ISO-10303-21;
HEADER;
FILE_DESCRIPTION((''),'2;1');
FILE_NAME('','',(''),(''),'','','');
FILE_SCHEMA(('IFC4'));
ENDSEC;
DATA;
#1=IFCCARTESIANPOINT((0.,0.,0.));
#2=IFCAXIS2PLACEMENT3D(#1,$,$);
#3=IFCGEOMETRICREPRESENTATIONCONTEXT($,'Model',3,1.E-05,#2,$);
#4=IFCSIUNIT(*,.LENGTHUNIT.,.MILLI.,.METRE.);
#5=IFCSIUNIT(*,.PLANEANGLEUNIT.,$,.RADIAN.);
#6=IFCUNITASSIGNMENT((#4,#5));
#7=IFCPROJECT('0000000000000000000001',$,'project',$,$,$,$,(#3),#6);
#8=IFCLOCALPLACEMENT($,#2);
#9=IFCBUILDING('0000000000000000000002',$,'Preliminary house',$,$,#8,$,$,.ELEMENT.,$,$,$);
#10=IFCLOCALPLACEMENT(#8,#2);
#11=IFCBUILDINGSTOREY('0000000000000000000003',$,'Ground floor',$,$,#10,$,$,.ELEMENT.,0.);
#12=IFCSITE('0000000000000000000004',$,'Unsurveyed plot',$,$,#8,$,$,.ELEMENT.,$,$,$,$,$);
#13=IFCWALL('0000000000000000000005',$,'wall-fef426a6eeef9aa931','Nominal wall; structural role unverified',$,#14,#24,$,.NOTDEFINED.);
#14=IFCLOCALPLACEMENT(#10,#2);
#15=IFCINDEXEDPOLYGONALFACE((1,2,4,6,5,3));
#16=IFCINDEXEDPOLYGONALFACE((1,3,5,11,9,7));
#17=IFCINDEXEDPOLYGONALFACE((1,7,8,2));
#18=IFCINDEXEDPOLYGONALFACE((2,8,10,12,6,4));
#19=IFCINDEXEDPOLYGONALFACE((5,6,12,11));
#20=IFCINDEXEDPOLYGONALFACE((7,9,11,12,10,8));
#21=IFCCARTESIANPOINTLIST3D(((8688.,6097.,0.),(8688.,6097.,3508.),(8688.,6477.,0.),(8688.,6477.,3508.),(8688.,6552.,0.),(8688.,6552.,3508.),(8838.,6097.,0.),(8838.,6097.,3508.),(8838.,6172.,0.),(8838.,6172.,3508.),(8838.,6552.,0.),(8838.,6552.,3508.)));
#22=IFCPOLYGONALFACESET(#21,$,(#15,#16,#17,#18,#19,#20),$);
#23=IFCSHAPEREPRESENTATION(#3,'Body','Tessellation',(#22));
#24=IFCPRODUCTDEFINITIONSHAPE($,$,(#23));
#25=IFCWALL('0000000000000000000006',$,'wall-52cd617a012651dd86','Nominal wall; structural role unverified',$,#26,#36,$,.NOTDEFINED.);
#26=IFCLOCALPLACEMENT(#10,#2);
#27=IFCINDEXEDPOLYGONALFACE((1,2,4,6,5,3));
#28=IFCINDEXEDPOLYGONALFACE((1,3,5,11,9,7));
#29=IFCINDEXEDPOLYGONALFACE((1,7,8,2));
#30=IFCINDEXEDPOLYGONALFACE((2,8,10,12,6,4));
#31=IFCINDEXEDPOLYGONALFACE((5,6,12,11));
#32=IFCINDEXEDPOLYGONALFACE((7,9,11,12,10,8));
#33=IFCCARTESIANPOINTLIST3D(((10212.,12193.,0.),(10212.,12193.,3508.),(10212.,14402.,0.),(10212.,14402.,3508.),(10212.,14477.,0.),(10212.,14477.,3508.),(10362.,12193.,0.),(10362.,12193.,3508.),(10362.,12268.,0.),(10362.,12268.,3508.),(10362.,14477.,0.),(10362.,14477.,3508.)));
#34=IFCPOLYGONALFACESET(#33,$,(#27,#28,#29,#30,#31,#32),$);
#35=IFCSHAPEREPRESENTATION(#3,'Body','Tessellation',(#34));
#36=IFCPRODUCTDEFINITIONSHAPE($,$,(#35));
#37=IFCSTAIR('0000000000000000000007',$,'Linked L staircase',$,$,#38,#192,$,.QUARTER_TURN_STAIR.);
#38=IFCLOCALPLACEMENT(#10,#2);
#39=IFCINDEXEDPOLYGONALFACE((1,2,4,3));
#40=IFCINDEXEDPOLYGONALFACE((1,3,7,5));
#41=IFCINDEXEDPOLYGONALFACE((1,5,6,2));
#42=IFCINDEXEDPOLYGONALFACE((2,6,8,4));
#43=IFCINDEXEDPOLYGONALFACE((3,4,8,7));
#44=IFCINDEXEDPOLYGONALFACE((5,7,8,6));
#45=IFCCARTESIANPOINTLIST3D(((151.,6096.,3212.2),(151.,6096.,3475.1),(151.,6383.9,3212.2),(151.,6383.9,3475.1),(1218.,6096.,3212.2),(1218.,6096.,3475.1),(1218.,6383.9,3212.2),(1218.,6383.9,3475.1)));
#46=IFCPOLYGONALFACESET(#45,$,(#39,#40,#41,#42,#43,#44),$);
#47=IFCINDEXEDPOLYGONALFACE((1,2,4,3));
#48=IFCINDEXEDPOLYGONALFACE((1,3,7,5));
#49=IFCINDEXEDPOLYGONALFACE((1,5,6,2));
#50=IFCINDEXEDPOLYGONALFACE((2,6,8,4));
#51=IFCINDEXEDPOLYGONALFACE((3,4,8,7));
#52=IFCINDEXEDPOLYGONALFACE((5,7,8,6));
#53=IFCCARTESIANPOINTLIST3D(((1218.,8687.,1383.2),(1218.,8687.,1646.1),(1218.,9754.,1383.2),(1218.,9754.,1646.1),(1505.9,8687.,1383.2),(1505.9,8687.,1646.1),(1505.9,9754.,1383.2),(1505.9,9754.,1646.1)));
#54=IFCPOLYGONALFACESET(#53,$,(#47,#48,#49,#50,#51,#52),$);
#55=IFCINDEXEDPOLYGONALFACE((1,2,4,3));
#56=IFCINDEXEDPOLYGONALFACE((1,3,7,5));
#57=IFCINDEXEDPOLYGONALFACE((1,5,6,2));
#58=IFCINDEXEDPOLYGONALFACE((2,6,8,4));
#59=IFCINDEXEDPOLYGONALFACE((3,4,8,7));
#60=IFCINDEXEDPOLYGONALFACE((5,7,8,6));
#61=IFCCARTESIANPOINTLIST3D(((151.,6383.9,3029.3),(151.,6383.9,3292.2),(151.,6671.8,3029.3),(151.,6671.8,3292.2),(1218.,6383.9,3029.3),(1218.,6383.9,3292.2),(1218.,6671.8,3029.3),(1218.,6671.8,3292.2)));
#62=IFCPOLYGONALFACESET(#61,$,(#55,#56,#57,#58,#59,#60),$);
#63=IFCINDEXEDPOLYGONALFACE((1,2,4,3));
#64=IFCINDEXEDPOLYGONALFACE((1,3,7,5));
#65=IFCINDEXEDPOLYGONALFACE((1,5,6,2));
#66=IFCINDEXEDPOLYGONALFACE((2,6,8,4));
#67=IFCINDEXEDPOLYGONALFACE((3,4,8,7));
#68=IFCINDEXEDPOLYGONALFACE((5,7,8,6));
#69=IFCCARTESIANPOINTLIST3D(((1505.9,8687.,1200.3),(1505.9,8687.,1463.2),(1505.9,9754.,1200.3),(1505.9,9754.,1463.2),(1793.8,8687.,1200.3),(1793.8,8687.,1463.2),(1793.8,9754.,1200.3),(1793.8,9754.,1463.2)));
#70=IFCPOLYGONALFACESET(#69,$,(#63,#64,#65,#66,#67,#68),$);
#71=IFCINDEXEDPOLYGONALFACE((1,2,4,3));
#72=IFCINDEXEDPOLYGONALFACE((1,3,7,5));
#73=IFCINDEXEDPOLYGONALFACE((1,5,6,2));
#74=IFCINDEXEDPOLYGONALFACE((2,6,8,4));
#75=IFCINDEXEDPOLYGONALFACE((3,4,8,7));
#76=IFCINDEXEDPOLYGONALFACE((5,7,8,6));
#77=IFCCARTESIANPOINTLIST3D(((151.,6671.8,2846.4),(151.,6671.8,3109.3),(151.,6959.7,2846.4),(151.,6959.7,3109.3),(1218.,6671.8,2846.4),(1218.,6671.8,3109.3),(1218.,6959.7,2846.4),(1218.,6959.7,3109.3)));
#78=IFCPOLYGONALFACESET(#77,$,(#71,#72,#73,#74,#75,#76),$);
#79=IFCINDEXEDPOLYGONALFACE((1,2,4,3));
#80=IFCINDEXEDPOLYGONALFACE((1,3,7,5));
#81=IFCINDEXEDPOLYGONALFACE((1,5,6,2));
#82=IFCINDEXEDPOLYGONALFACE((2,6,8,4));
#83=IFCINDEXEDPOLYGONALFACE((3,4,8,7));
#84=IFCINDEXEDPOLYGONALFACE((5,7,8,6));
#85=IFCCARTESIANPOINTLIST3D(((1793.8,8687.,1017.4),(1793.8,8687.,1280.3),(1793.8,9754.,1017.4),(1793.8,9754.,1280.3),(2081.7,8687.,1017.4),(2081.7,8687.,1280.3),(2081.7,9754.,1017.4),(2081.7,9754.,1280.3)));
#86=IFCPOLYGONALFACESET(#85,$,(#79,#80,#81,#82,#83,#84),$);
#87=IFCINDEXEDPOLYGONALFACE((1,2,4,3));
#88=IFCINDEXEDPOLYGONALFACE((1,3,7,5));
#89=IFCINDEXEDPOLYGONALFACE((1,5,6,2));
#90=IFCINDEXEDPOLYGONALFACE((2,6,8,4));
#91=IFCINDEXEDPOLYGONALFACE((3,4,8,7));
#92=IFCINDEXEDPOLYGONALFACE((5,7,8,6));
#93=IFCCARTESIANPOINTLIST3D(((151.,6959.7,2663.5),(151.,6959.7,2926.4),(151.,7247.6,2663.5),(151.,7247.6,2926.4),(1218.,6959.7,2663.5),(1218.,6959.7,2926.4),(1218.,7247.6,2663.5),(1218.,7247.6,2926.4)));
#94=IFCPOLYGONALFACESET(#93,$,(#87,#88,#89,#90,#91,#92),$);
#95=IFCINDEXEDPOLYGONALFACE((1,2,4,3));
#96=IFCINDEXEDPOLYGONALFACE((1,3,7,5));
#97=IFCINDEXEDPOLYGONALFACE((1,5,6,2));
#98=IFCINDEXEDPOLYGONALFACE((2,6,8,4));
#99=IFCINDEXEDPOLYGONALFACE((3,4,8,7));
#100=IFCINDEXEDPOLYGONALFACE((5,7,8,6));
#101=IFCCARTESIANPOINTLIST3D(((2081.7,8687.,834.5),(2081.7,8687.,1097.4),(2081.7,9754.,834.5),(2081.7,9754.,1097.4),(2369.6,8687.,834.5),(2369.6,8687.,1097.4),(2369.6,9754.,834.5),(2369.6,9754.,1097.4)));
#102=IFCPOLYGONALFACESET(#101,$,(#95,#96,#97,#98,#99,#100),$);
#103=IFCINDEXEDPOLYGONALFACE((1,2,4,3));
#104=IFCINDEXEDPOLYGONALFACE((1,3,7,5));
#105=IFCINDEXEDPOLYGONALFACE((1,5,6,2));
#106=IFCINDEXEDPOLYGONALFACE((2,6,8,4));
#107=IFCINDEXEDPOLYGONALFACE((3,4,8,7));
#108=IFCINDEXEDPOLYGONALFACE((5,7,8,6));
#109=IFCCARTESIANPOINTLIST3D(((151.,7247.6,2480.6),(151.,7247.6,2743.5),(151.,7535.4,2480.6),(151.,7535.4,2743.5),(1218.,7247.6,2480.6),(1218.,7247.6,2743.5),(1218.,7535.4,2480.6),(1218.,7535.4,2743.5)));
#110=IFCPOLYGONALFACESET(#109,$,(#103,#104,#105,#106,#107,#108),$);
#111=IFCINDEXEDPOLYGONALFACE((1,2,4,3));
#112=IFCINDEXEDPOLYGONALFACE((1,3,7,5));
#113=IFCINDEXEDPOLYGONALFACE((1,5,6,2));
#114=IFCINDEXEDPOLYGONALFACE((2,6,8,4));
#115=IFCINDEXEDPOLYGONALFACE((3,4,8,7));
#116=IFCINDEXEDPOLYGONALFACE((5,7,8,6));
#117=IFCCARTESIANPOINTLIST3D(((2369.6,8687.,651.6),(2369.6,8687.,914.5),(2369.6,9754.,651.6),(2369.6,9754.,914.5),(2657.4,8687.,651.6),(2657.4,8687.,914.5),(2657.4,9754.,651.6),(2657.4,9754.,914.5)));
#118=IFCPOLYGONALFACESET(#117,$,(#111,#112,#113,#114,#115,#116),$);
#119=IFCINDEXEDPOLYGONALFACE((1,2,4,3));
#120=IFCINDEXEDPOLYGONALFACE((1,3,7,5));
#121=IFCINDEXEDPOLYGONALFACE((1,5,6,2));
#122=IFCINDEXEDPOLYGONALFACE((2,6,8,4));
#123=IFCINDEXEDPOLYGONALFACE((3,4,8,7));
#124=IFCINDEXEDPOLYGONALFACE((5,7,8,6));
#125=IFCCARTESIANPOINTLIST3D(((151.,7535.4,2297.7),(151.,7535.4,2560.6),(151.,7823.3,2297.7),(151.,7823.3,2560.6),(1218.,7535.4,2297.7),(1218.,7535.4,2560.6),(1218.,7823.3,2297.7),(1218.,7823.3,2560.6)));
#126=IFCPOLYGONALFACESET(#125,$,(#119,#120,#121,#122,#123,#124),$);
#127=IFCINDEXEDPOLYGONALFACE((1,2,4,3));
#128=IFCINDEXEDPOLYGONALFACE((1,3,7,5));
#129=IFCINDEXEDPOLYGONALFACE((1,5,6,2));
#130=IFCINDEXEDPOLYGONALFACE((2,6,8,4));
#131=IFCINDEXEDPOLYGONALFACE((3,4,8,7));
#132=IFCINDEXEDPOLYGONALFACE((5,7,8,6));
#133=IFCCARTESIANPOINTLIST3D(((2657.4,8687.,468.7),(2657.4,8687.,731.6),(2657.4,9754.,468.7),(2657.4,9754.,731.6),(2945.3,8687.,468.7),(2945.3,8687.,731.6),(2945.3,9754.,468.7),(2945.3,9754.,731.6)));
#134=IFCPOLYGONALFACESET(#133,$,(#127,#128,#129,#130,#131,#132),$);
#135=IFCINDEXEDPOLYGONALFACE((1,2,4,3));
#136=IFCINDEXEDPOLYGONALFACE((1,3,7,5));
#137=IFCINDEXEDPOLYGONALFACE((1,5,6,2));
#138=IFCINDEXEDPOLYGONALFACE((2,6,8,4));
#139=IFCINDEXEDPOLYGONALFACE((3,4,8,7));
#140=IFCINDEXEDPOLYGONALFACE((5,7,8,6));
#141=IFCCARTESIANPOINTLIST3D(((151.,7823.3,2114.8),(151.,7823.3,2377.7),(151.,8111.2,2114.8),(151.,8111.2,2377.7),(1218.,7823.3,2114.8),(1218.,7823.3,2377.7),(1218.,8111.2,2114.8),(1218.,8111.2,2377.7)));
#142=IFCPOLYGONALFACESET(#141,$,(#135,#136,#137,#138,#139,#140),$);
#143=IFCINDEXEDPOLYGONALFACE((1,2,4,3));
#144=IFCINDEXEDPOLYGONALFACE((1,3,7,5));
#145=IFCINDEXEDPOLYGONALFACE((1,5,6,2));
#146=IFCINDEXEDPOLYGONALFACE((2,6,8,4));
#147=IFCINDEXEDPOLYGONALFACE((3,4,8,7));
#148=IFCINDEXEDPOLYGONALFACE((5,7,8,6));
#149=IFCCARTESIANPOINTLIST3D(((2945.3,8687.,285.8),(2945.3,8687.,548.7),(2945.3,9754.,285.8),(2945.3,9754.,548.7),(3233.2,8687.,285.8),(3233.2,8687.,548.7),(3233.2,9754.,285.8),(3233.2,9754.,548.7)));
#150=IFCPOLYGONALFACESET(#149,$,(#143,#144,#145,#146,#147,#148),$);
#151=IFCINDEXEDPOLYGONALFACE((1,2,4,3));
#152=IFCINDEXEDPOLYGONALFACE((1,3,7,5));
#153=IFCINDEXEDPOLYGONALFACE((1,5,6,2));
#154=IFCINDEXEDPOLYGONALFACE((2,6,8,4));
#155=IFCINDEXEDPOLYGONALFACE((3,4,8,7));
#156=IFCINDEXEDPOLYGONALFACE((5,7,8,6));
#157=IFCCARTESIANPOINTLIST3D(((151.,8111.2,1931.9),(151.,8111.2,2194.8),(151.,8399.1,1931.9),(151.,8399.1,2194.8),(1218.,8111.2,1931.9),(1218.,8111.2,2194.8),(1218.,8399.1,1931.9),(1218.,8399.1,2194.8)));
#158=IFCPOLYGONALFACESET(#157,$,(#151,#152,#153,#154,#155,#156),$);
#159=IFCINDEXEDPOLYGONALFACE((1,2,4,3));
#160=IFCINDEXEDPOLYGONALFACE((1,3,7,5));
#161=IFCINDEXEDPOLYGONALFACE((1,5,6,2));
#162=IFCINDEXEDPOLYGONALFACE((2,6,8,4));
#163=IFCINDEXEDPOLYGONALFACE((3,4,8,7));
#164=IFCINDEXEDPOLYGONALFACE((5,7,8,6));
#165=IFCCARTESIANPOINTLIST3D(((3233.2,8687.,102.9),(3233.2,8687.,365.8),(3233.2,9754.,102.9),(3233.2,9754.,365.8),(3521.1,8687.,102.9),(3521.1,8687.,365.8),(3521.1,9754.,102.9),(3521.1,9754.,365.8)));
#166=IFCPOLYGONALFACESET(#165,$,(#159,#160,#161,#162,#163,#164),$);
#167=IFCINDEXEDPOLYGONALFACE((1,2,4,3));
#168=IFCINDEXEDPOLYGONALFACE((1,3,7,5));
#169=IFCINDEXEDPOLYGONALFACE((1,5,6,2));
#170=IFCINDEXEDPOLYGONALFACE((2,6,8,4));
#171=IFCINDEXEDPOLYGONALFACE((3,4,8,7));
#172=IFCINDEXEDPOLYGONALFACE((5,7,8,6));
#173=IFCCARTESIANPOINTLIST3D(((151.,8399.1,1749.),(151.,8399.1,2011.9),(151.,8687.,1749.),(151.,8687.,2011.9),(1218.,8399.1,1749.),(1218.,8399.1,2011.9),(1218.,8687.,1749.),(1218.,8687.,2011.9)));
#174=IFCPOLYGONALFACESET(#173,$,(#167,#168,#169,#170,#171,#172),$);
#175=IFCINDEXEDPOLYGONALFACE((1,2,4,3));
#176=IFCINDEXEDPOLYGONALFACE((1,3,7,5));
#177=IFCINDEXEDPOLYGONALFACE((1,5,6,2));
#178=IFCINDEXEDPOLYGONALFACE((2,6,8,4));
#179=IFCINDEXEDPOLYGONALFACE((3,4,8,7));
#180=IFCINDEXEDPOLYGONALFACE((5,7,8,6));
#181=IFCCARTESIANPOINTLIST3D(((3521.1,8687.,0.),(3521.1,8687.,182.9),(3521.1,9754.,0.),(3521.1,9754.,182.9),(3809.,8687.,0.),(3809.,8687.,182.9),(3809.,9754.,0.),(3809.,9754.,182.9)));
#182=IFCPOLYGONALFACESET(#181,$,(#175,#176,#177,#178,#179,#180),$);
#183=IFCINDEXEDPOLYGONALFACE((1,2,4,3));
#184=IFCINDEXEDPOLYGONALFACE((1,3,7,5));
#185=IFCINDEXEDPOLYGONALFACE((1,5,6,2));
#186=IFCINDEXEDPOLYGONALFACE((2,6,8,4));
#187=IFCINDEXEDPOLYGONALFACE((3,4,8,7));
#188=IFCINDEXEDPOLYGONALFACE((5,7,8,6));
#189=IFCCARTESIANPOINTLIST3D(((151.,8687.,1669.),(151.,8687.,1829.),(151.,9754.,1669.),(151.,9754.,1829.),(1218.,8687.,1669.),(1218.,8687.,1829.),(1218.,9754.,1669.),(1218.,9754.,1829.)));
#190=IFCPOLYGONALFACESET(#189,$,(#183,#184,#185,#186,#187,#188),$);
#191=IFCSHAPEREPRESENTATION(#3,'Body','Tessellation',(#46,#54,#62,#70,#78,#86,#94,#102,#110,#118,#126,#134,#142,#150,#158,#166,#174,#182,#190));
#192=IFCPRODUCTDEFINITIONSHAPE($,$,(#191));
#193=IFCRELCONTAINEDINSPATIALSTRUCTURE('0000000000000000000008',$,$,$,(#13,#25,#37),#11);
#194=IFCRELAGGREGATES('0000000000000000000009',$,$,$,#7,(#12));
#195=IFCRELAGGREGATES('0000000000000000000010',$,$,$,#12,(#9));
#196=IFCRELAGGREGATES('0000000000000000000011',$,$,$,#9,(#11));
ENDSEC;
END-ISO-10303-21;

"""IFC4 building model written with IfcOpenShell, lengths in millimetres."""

from ifc_helpers import new_model, si_unit, frame, origin, place, context, project, spatial, polyline, outline, extrude, element, save


model = new_model("IFC4")

# Units and contexts
model_context = context("Model", 3, precision=1e-05, world=origin())
ifc_project = project(units=[si_unit("LENGTHUNIT", "METRE", prefix="MILLI"), si_unit("PLANEANGLEUNIT", "RADIAN")], contexts=[model_context])

# Site, building, storey
placement_1 = place(None, origin())
site = spatial("IfcSite", under=ifc_project, at=placement_1, Name="Unsurveyed plot", CompositionType="ELEMENT")
building = spatial("IfcBuilding", under=site, at=placement_1, Name="Preliminary house", CompositionType="ELEMENT")
placement_2 = place(placement_1, origin())
storey = spatial("IfcBuildingStorey", under=building, at=placement_2, Name="Ground floor", CompositionType="ELEMENT", Elevation=0.0)

# Wall
element("IfcWall", 1, at=placement_2, inside=storey, Name="wall-fef426a6eeef9aa931", Description="Nominal wall; structural role unverified", PredefinedType="NOTDEFINED", context=model_context, shape_type="SweptSolid", body=[
    extrude(outline(polyline([(8688.0, 6477.0), (8688.0, 6552.0), (8838.0, 6552.0), (8838.0, 6172.0), (8838.0, 6097.0), (8688.0, 6097.0), (8688.0, 6477.0)])), origin(), (0.0, 0.0, 1.0), 3508.0),
])

# Wall
element("IfcWall", 2, at=placement_2, inside=storey, Name="wall-52cd617a012651dd86", Description="Nominal wall; structural role unverified", PredefinedType="NOTDEFINED", context=model_context, shape_type="SweptSolid", body=[
    extrude(outline(polyline([(10212.0, 14402.0), (10212.0, 14477.0), (10362.0, 14477.0), (10362.0, 12268.0), (10362.0, 12193.0), (10212.0, 12193.0), (10212.0, 14402.0)])), origin(), (0.0, 0.0, 1.0), 3508.0),
])

# Stair
element("IfcStair", 3, at=placement_2, inside=storey, Name="Linked L staircase", PredefinedType="QUARTER_TURN_STAIR", context=model_context, shape_type="SweptSolid", body=[
    extrude(outline(polyline([(1218.0, 6096.0), (1218.0, 6383.9), (151.0, 6383.9), (151.0, 6096.0), (1218.0, 6096.0)])), frame((0.0, 0.0, 3212.2)), (0.0, 0.0, 1.0), 262.9),
    extrude(outline(polyline([(1505.9, 8687.0), (1505.9, 9754.0), (1218.0, 9754.0), (1218.0, 8687.0), (1505.9, 8687.0)])), frame((0.0, 0.0, 1383.2)), (0.0, 0.0, 1.0), 262.9),
    extrude(outline(polyline([(1218.0, 6383.9), (1218.0, 6671.8), (151.0, 6671.8), (151.0, 6383.9), (1218.0, 6383.9)])), frame((0.0, 0.0, 3029.3)), (0.0, 0.0, 1.0), 262.9),
    extrude(outline(polyline([(1793.8, 8687.0), (1793.8, 9754.0), (1505.9, 9754.0), (1505.9, 8687.0), (1793.8, 8687.0)])), frame((0.0, 0.0, 1200.3)), (0.0, 0.0, 1.0), 262.9),
    extrude(outline(polyline([(1218.0, 6671.8), (1218.0, 6959.7), (151.0, 6959.7), (151.0, 6671.8), (1218.0, 6671.8)])), frame((0.0, 0.0, 2846.4)), (0.0, 0.0, 1.0), 262.9),
    extrude(outline(polyline([(2081.7, 8687.0), (2081.7, 9754.0), (1793.8, 9754.0), (1793.8, 8687.0), (2081.7, 8687.0)])), frame((0.0, 0.0, 1017.4)), (0.0, 0.0, 1.0), 262.9),
    extrude(outline(polyline([(1218.0, 6959.7), (1218.0, 7247.6), (151.0, 7247.6), (151.0, 6959.7), (1218.0, 6959.7)])), frame((0.0, 0.0, 2663.5)), (0.0, 0.0, 1.0), 262.9),
    extrude(outline(polyline([(2369.6, 8687.0), (2369.6, 9754.0), (2081.7, 9754.0), (2081.7, 8687.0), (2369.6, 8687.0)])), frame((0.0, 0.0, 834.5)), (0.0, 0.0, 1.0), 262.9),
    extrude(outline(polyline([(1218.0, 7247.6), (1218.0, 7535.4), (151.0, 7535.4), (151.0, 7247.6), (1218.0, 7247.6)])), frame((0.0, 0.0, 2480.6)), (0.0, 0.0, 1.0), 262.9),
    extrude(outline(polyline([(2657.4, 8687.0), (2657.4, 9754.0), (2369.6, 9754.0), (2369.6, 8687.0), (2657.4, 8687.0)])), frame((0.0, 0.0, 651.6)), (0.0, 0.0, 1.0), 262.9),
    extrude(outline(polyline([(1218.0, 7535.4), (1218.0, 7823.3), (151.0, 7823.3), (151.0, 7535.4), (1218.0, 7535.4)])), frame((0.0, 0.0, 2297.7)), (0.0, 0.0, 1.0), 262.9),
    extrude(outline(polyline([(2945.3, 8687.0), (2945.3, 9754.0), (2657.4, 9754.0), (2657.4, 8687.0), (2945.3, 8687.0)])), frame((0.0, 0.0, 468.7)), (0.0, 0.0, 1.0), 262.9),
    extrude(outline(polyline([(1218.0, 7823.3), (1218.0, 8111.2), (151.0, 8111.2), (151.0, 7823.3), (1218.0, 7823.3)])), frame((0.0, 0.0, 2114.8)), (0.0, 0.0, 1.0), 262.9),
    extrude(outline(polyline([(3233.2, 8687.0), (3233.2, 9754.0), (2945.3, 9754.0), (2945.3, 8687.0), (3233.2, 8687.0)])), frame((0.0, 0.0, 285.8)), (0.0, 0.0, 1.0), 262.9),
    extrude(outline(polyline([(1218.0, 8111.2), (1218.0, 8399.1), (151.0, 8399.1), (151.0, 8111.2), (1218.0, 8111.2)])), frame((0.0, 0.0, 1931.9)), (0.0, 0.0, 1.0), 262.9),
    extrude(outline(polyline([(3521.1, 8687.0), (3521.1, 9754.0), (3233.2, 9754.0), (3233.2, 8687.0), (3521.1, 8687.0)])), frame((0.0, 0.0, 102.9)), (0.0, 0.0, 1.0), 262.9),
    extrude(outline(polyline([(1218.0, 8399.1), (1218.0, 8687.0), (151.0, 8687.0), (151.0, 8399.1), (1218.0, 8399.1)])), frame((0.0, 0.0, 1749.0)), (0.0, 0.0, 1.0), 262.9),
    extrude(outline(polyline([(3809.0, 8687.0), (3809.0, 9754.0), (3521.1, 9754.0), (3521.1, 8687.0), (3809.0, 8687.0)])), origin(), (0.0, 0.0, 1.0), 182.9),
    extrude(outline(polyline([(1218.0, 8687.0), (1218.0, 9754.0), (151.0, 9754.0), (151.0, 8687.0), (1218.0, 8687.0)])), frame((0.0, 0.0, 1669.0)), (0.0, 0.0, 1.0), 160.0),
])

save(model, "model.ifc")
